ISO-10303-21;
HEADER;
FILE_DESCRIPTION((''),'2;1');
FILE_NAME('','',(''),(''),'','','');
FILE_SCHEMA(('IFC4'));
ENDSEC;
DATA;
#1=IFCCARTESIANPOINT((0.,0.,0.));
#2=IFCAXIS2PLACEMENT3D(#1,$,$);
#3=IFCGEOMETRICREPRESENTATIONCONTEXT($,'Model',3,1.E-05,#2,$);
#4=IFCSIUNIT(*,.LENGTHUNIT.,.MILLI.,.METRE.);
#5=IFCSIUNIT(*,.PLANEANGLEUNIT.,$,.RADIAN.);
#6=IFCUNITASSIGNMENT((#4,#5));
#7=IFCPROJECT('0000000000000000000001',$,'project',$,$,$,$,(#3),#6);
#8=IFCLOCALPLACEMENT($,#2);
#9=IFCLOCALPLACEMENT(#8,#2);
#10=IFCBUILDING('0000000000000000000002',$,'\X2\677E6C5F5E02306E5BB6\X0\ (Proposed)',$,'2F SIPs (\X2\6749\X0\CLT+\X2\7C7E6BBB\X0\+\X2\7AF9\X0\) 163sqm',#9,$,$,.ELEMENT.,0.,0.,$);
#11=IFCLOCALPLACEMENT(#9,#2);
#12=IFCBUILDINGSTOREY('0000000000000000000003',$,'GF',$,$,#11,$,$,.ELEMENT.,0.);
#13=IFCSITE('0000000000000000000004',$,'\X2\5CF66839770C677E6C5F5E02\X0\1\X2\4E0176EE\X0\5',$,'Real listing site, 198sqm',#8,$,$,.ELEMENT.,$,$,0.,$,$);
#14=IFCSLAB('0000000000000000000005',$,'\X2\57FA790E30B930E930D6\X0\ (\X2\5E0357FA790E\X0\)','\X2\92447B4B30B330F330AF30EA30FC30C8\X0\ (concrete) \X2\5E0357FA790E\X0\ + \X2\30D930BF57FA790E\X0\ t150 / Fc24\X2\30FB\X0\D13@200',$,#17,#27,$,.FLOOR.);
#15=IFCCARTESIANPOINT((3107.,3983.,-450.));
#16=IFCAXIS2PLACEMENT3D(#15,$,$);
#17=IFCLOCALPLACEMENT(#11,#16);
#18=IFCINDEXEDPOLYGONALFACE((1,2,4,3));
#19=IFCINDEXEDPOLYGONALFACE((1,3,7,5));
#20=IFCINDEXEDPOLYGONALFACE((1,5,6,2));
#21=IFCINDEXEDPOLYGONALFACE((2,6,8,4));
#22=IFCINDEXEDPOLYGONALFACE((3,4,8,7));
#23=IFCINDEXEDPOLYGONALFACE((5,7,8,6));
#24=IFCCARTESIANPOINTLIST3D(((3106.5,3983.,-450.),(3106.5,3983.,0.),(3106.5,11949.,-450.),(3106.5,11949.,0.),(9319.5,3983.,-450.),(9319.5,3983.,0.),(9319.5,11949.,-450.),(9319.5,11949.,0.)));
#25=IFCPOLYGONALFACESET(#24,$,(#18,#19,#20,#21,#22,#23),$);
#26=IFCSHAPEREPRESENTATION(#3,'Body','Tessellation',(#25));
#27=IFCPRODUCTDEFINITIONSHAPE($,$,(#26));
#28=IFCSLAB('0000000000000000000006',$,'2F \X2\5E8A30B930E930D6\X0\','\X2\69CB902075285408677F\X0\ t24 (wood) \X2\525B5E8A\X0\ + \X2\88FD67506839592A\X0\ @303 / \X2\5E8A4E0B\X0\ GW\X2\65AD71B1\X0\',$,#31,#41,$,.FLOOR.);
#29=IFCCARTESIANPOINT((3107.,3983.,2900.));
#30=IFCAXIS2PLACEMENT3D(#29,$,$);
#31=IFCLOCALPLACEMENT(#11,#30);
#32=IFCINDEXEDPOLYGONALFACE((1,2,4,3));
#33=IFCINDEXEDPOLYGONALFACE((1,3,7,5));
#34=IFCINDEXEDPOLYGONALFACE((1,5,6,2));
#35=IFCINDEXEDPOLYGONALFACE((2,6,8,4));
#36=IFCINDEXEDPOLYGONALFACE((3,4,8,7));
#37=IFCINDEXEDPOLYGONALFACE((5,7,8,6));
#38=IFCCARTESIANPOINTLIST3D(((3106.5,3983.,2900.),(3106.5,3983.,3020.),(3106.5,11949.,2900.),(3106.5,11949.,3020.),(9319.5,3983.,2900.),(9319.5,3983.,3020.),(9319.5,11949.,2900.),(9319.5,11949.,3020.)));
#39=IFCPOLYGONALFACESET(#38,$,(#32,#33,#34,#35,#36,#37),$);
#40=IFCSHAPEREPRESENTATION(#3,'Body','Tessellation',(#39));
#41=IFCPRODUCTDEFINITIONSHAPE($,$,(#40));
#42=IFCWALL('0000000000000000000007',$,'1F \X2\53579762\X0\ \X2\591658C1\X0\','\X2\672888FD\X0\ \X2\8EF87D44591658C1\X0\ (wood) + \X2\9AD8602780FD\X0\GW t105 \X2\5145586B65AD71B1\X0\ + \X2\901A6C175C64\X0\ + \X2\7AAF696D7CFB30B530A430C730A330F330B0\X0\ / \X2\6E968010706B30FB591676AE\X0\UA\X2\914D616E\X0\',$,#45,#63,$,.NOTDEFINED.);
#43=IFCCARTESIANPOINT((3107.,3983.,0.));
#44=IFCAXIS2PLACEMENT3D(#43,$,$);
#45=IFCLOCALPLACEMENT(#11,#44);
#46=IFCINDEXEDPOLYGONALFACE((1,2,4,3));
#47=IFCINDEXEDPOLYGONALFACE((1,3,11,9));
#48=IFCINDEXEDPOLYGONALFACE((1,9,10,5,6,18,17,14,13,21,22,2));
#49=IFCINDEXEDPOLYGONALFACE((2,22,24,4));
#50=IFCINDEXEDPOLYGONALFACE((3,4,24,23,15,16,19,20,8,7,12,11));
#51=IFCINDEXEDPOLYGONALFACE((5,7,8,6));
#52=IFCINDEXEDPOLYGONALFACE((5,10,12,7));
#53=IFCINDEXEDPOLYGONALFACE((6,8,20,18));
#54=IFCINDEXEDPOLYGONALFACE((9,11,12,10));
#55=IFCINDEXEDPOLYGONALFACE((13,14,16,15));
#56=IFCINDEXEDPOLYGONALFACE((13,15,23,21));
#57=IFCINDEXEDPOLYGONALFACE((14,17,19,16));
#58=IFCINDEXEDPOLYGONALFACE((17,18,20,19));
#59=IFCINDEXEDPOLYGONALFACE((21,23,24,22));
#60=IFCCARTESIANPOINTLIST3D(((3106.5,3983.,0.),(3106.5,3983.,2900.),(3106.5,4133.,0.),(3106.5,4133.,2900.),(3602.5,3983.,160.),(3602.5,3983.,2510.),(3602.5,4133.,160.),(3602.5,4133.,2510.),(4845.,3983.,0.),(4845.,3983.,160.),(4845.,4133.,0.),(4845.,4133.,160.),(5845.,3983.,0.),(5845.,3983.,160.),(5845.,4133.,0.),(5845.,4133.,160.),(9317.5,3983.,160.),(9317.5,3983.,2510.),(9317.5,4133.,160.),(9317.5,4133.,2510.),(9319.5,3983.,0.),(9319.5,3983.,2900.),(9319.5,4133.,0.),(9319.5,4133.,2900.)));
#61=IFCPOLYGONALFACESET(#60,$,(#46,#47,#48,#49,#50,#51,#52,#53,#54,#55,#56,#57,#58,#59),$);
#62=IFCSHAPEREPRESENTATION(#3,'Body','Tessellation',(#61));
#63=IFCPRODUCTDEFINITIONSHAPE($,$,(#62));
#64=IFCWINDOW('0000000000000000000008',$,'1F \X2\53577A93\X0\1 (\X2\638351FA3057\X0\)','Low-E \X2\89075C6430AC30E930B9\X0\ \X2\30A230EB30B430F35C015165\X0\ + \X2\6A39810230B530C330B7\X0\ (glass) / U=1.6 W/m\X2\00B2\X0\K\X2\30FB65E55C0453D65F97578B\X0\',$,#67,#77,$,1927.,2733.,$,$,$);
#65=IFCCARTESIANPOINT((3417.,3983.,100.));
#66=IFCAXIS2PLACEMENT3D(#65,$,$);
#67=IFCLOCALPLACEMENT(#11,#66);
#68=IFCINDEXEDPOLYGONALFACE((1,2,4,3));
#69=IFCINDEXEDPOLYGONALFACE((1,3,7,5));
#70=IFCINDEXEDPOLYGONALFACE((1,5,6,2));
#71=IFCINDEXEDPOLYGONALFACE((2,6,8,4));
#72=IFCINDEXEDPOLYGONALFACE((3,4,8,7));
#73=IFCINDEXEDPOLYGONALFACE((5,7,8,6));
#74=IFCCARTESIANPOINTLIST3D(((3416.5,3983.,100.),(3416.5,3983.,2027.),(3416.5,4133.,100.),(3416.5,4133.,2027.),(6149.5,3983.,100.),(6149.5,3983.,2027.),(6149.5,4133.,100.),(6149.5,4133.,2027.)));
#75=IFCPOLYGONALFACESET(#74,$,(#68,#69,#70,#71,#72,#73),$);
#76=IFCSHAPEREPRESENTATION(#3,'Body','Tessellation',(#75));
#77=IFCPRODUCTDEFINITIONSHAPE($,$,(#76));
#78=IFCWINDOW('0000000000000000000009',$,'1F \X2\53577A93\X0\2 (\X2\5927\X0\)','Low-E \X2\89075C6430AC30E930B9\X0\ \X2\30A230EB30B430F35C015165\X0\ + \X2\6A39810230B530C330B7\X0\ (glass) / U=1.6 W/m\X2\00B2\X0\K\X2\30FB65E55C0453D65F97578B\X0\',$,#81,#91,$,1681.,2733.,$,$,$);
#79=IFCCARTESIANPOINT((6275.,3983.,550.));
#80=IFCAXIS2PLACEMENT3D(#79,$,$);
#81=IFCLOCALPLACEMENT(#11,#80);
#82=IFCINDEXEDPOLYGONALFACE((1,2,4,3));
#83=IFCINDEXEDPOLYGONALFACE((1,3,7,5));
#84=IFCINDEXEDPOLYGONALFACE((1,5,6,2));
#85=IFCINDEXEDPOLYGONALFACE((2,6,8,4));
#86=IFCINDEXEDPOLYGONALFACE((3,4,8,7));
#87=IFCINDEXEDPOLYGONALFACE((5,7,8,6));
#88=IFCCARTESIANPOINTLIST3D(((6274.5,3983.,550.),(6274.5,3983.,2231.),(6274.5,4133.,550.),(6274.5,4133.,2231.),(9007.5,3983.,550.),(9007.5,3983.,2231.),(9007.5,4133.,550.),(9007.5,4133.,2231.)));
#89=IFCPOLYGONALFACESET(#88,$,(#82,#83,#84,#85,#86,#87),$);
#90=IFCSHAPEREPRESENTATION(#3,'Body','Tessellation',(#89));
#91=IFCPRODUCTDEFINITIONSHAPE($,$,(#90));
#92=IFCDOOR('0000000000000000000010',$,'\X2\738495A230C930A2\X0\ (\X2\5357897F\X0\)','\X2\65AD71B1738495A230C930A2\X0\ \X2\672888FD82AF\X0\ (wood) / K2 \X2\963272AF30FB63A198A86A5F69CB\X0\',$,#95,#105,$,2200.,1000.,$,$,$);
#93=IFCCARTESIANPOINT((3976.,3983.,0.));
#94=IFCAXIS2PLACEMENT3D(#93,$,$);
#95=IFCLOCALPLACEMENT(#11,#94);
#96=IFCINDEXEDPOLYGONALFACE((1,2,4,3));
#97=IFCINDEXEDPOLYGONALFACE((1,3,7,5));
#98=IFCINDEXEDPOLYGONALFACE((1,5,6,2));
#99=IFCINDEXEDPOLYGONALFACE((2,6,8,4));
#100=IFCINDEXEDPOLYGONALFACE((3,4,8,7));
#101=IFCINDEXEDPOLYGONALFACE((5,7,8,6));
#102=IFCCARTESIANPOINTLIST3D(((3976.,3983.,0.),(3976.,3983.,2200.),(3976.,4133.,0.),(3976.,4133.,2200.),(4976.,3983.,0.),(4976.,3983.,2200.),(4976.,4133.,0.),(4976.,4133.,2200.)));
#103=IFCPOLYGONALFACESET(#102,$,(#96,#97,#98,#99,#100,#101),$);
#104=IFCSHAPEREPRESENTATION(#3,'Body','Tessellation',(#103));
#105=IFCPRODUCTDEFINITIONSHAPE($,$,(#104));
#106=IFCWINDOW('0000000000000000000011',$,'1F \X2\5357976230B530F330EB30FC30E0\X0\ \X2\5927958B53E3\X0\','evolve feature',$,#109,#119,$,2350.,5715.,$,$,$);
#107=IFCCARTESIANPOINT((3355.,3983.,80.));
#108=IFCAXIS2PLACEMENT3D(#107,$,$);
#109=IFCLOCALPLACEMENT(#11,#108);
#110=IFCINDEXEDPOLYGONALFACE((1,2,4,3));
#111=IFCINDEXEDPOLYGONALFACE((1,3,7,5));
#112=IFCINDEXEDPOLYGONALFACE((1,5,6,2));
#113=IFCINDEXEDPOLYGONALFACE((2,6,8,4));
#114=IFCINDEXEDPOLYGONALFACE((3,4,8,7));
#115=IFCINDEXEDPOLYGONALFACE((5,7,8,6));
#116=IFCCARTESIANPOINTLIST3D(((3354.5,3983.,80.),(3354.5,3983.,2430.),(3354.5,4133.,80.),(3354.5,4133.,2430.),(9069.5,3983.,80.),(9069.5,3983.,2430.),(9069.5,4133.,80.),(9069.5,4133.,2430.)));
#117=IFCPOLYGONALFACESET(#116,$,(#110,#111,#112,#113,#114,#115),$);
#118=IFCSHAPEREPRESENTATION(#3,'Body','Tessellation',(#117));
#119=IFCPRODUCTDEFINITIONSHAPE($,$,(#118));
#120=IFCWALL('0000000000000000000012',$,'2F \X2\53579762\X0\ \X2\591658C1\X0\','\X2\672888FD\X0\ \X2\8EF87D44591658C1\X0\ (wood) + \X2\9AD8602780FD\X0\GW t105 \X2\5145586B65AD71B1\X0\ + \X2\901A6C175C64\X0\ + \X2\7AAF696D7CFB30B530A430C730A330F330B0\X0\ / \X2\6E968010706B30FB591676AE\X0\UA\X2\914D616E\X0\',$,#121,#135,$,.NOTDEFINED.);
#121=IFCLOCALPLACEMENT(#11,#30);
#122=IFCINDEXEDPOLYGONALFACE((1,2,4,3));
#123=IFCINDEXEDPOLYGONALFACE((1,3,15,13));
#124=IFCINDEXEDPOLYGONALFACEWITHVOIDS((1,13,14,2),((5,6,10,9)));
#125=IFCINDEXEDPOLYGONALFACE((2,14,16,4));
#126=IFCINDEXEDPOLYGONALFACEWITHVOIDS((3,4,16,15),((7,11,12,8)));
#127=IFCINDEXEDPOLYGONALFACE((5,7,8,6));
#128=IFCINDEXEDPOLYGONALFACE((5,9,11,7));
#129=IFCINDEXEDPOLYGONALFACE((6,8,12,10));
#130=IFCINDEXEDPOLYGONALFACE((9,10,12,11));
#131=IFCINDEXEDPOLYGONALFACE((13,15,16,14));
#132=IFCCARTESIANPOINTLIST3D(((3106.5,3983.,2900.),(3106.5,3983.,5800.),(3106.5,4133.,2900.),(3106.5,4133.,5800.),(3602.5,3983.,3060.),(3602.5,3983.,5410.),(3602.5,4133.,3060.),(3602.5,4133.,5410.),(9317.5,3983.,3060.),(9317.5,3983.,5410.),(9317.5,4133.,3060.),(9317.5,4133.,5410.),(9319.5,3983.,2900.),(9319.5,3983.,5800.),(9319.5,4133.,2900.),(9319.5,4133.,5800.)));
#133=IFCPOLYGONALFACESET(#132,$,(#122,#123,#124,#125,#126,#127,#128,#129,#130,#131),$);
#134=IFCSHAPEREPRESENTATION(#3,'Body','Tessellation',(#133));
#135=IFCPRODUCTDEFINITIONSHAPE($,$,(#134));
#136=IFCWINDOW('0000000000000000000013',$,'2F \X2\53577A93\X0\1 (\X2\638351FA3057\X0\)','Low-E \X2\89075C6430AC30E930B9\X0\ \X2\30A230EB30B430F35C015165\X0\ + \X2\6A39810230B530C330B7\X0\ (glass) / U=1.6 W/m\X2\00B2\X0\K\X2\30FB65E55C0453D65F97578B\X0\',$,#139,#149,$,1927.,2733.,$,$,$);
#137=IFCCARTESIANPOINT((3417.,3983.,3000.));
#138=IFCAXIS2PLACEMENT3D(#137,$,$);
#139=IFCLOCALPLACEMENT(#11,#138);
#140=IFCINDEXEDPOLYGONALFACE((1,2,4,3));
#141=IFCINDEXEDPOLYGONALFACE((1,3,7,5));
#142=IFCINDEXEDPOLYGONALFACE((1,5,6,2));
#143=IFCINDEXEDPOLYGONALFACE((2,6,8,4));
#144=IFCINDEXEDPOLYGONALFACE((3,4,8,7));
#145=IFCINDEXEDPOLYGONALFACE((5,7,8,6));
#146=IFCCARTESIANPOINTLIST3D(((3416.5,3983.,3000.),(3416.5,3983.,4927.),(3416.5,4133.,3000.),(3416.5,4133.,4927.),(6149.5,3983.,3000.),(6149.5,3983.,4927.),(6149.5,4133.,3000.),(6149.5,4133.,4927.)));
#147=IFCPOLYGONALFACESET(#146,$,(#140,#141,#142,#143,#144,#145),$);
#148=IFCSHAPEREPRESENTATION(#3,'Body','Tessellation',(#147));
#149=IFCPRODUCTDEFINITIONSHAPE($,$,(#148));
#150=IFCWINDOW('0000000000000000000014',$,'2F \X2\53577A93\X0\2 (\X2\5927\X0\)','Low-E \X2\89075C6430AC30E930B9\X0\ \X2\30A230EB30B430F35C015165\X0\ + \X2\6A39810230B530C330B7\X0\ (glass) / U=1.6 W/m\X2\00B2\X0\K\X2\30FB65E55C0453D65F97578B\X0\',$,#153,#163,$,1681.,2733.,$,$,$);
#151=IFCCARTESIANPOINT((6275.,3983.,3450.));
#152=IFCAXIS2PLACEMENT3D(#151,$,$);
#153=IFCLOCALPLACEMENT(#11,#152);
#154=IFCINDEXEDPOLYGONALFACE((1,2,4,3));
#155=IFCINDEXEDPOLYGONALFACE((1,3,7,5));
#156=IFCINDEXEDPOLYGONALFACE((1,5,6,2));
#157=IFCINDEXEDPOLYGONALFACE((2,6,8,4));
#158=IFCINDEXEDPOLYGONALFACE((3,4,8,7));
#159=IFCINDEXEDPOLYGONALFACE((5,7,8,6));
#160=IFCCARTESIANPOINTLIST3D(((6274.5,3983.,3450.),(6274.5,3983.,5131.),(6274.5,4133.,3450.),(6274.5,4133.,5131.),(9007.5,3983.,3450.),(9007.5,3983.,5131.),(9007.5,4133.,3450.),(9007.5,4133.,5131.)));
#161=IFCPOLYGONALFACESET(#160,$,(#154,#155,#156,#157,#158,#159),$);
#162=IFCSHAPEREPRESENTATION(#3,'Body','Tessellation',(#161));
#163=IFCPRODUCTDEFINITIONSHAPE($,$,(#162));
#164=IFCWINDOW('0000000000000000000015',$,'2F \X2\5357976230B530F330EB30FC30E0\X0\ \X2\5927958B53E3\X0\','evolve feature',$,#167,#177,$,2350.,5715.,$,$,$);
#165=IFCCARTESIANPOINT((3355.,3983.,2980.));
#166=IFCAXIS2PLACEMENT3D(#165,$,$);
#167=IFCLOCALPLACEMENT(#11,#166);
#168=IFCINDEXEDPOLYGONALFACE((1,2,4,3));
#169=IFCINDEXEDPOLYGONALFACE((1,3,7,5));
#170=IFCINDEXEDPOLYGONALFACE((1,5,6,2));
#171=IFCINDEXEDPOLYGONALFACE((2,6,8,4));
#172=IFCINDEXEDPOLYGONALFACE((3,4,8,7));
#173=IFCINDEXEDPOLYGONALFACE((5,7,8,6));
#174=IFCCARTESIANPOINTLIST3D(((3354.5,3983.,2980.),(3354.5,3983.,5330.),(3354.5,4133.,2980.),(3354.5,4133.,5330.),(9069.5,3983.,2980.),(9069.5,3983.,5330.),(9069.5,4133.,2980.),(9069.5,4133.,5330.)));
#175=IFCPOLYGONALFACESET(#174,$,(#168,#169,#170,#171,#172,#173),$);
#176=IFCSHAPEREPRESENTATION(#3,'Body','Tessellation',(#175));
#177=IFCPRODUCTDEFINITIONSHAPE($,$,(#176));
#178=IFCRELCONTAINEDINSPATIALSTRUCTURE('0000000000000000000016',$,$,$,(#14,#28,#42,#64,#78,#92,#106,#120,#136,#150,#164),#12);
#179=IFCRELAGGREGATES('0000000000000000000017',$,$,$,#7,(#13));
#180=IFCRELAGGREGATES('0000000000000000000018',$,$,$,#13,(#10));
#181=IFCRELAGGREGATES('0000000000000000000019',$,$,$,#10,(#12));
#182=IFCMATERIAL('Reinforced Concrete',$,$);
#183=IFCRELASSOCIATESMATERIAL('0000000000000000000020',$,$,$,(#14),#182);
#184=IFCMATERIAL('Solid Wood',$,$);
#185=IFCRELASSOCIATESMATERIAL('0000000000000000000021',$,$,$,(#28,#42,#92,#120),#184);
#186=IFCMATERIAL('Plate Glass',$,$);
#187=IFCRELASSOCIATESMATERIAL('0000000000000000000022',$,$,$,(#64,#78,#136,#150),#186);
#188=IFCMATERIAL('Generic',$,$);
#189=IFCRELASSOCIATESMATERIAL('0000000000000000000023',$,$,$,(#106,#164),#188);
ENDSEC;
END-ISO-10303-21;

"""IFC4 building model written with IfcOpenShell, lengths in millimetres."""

from ifc_helpers import new_model, si_unit, frame, frame_2d, origin, place, context, project, spatial, rectangle, extrude, material, element, fill, save


model = new_model("IFC4")

# Units and contexts
model_context = context("Model", 3, precision=1e-05, world=origin())
ifc_project = project(units=[si_unit("LENGTHUNIT", "METRE", prefix="MILLI"), si_unit("PLANEANGLEUNIT", "RADIAN")], contexts=[model_context])

# Site, building, storey
site_placement = place(None, origin())
site = spatial("IfcSite", under=ifc_project, at=site_placement, Name="島根県松江市1丁目5", ObjectType="Real listing site, 198sqm", CompositionType="ELEMENT", RefElevation=0.0)
building_placement = place(site_placement, origin())
building = spatial("IfcBuilding", under=site, at=building_placement, Name="松江市の家 (Proposed)", ObjectType="2F SIPs (杉CLT+籾殻+竹) 163sqm", CompositionType="ELEMENT", ElevationOfRefHeight=0.0, ElevationOfTerrain=0.0)
storey_placement = place(building_placement, origin())
storey = spatial("IfcBuildingStorey", under=building, at=storey_placement, Name="GF", CompositionType="ELEMENT", Elevation=0.0)

# Slabs
ifc_material_1 = material(Name="Reinforced Concrete")
slab_1_placement = place(storey_placement, frame((3107.0, 3983.0, -450.0)))
element("IfcSlab", 1, at=slab_1_placement, inside=storey, material=ifc_material_1, Name="基礎スラブ (布基礎)", Description="鉄筋コンクリート (concrete) 布基礎 + ベタ基礎 t150 / Fc24・D13@200", PredefinedType="FLOOR", context=model_context, shape_type="SweptSolid", body=[
    extrude(rectangle(XDim=6213.0, YDim=7966.0, at=frame_2d((3106.0, 3983.0))), frame((3107.0, 3983.0, -450.0)), (0.0, 0.0, 1.0), 450.0),
])
ifc_material_2 = material(Name="Solid Wood")
slab_2_placement = place(storey_placement, frame((3107.0, 3983.0, 2900.0)))
element("IfcSlab", 2, at=slab_2_placement, inside=storey, material=ifc_material_2, Name="2F 床スラブ", Description="構造用合板 t24 (wood) 剛床 + 製材根太 @303 / 床下 GW断熱", PredefinedType="FLOOR", context=model_context, shape_type="SweptSolid", body=[
    extrude(rectangle(XDim=6213.0, YDim=7966.0, at=frame_2d((3106.0, 3983.0))), frame((3107.0, 3983.0, 2900.0)), (0.0, 0.0, 1.0), 120.0),
])
ifc_material_3 = material(Name="Generic")

# Wall, openings, windows, door
wall_1_placement = place(storey_placement, frame((3107.0, 3983.0, 0.0)))
wall_1 = element("IfcWall", 3, at=wall_1_placement, inside=storey, material=ifc_material_2, Name="1F 南面 外壁", Description="木製 軸組外壁 (wood) + 高性能GW t105 充填断熱 + 通気層 + 窯業系サイディング / 準耐火・外皮UA配慮", PredefinedType="NOTDEFINED", context=model_context, shape_type="SweptSolid", body=[
    extrude(rectangle(XDim=6213.0, YDim=150.0, at=frame_2d((3106.0, 75.0))), frame((3107.0, 3983.0, 0.0)), (0.0, 0.0, 1.0), 2900.0),
])
opening_1_placement = place(storey_placement, frame((3417.0, 3983.0, 100.0)))
opening_1 = element("IfcOpeningElement", 4, at=opening_1_placement, cuts=wall_1, PredefinedType="NOTDEFINED", context=model_context, shape_type="SweptSolid", body=[
    extrude(rectangle(XDim=2733.0, YDim=150.0, at=frame_2d((1366.0, 75.0))), frame((3417.0, 3983.0, 100.0)), (0.0, 0.0, 1.0), 1927.0),
])
opening_2_placement = place(storey_placement, frame((6275.0, 3983.0, 550.0)))
opening_2 = element("IfcOpeningElement", 5, at=opening_2_placement, cuts=wall_1, PredefinedType="NOTDEFINED", context=model_context, shape_type="SweptSolid", body=[
    extrude(rectangle(XDim=2733.0, YDim=150.0, at=frame_2d((1366.0, 75.0))), frame((6275.0, 3983.0, 550.0)), (0.0, 0.0, 1.0), 1681.0),
])
opening_3_placement = place(storey_placement, frame((3976.0, 3983.0, 0.0)))
opening_3 = element("IfcOpeningElement", 6, at=opening_3_placement, cuts=wall_1, PredefinedType="NOTDEFINED", context=model_context, shape_type="SweptSolid", body=[
    extrude(rectangle(XDim=1000.0, YDim=150.0, at=frame_2d((500.0, 75.0))), frame((3976.0, 3983.0, 0.0)), (0.0, 0.0, 1.0), 2200.0),
])
opening_4_placement = place(storey_placement, frame((3355.0, 3983.0, 80.0)))
opening_4 = element("IfcOpeningElement", 7, at=opening_4_placement, cuts=wall_1, PredefinedType="NOTDEFINED", context=model_context, shape_type="SweptSolid", body=[
    extrude(rectangle(XDim=5715.0, YDim=150.0, at=frame_2d((2857.0, 75.0))), frame((3355.0, 3983.0, 80.0)), (0.0, 0.0, 1.0), 2350.0),
])
ifc_material_4 = material(Name="Plate Glass")
window_1_placement = place(storey_placement, frame((3417.0, 3983.0, 100.0)))
window_1 = element("IfcWindow", 8, at=window_1_placement, inside=storey, material=ifc_material_4, Name="1F 南窓1 (掃出し)", Description="Low-E 複層ガラス アルゴン封入 + 樹脂サッシ (glass) / U=1.6 W/m²K・日射取得型", OverallHeight=1927.0, OverallWidth=2733.0, context=model_context, shape_type="SweptSolid", body=[
    extrude(rectangle(XDim=2733.0, YDim=150.0, at=frame_2d((1366.0, 75.0))), frame((3417.0, 3983.0, 100.0)), (0.0, 0.0, 1.0), 1927.0),
])
fill(opening_1, window_1)
window_2_placement = place(storey_placement, frame((6275.0, 3983.0, 550.0)))
window_2 = element("IfcWindow", 9, at=window_2_placement, inside=storey, material=ifc_material_4, Name="1F 南窓2 (大)", Description="Low-E 複層ガラス アルゴン封入 + 樹脂サッシ (glass) / U=1.6 W/m²K・日射取得型", OverallHeight=1681.0, OverallWidth=2733.0, context=model_context, shape_type="SweptSolid", body=[
    extrude(rectangle(XDim=2733.0, YDim=150.0, at=frame_2d((1366.0, 75.0))), frame((6275.0, 3983.0, 550.0)), (0.0, 0.0, 1.0), 1681.0),
])
fill(opening_2, window_2)
door_placement = place(storey_placement, frame((3976.0, 3983.0, 0.0)))
door = element("IfcDoor", 10, at=door_placement, inside=storey, material=ifc_material_2, Name="玄関ドア (南西)", Description="断熱玄関ドア 木製芯 (wood) / K2 防犯・採風機構", OverallHeight=2200.0, OverallWidth=1000.0, context=model_context, shape_type="SweptSolid", body=[
    extrude(rectangle(XDim=1000.0, YDim=150.0, at=frame_2d((500.0, 75.0))), frame((3976.0, 3983.0, 0.0)), (0.0, 0.0, 1.0), 2200.0),
])
fill(opening_3, door)
window_3_placement = place(storey_placement, frame((3355.0, 3983.0, 80.0)))
window_3 = element("IfcWindow", 11, at=window_3_placement, inside=storey, material=ifc_material_3, Name="1F 南面サンルーム 大開口", Description="evolve feature", OverallHeight=2350.0, OverallWidth=5715.0, context=model_context, shape_type="SweptSolid", body=[
    extrude(rectangle(XDim=5715.0, YDim=150.0, at=frame_2d((2857.0, 75.0))), frame((3355.0, 3983.0, 80.0)), (0.0, 0.0, 1.0), 2350.0),
])
fill(opening_4, window_3)

# Wall, openings, windows
wall_2_placement = place(storey_placement, frame((3107.0, 3983.0, 2900.0)))
wall_2 = element("IfcWall", 12, at=wall_2_placement, inside=storey, material=ifc_material_2, Name="2F 南面 外壁", Description="木製 軸組外壁 (wood) + 高性能GW t105 充填断熱 + 通気層 + 窯業系サイディング / 準耐火・外皮UA配慮", PredefinedType="NOTDEFINED", context=model_context, shape_type="SweptSolid", body=[
    extrude(rectangle(XDim=6213.0, YDim=150.0, at=frame_2d((3106.0, 75.0))), frame((3107.0, 3983.0, 2900.0)), (0.0, 0.0, 1.0), 2900.0),
])
opening_5_placement = place(storey_placement, frame((3417.0, 3983.0, 3000.0)))
opening_5 = element("IfcOpeningElement", 13, at=opening_5_placement, cuts=wall_2, PredefinedType="NOTDEFINED", context=model_context, shape_type="SweptSolid", body=[
    extrude(rectangle(XDim=2733.0, YDim=150.0, at=frame_2d((1366.0, 75.0))), frame((3417.0, 3983.0, 3000.0)), (0.0, 0.0, 1.0), 1927.0),
])
opening_6_placement = place(storey_placement, frame((6275.0, 3983.0, 3450.0)))
opening_6 = element("IfcOpeningElement", 14, at=opening_6_placement, cuts=wall_2, PredefinedType="NOTDEFINED", context=model_context, shape_type="SweptSolid", body=[
    extrude(rectangle(XDim=2733.0, YDim=150.0, at=frame_2d((1366.0, 75.0))), frame((6275.0, 3983.0, 3450.0)), (0.0, 0.0, 1.0), 1681.0),
])
opening_7_placement = place(storey_placement, frame((3355.0, 3983.0, 2980.0)))
opening_7 = element("IfcOpeningElement", 15, at=opening_7_placement, cuts=wall_2, PredefinedType="NOTDEFINED", context=model_context, shape_type="SweptSolid", body=[
    extrude(rectangle(XDim=5715.0, YDim=150.0, at=frame_2d((2857.0, 75.0))), frame((3355.0, 3983.0, 2980.0)), (0.0, 0.0, 1.0), 2350.0),
])
window_4_placement = place(storey_placement, frame((3417.0, 3983.0, 3000.0)))
window_4 = element("IfcWindow", 16, at=window_4_placement, inside=storey, material=ifc_material_4, Name="2F 南窓1 (掃出し)", Description="Low-E 複層ガラス アルゴン封入 + 樹脂サッシ (glass) / U=1.6 W/m²K・日射取得型", OverallHeight=1927.0, OverallWidth=2733.0, context=model_context, shape_type="SweptSolid", body=[
    extrude(rectangle(XDim=2733.0, YDim=150.0, at=frame_2d((1366.0, 75.0))), frame((3417.0, 3983.0, 3000.0)), (0.0, 0.0, 1.0), 1927.0),
])
fill(opening_5, window_4)
window_5_placement = place(storey_placement, frame((6275.0, 3983.0, 3450.0)))
window_5 = element("IfcWindow", 17, at=window_5_placement, inside=storey, material=ifc_material_4, Name="2F 南窓2 (大)", Description="Low-E 複層ガラス アルゴン封入 + 樹脂サッシ (glass) / U=1.6 W/m²K・日射取得型", OverallHeight=1681.0, OverallWidth=2733.0, context=model_context, shape_type="SweptSolid", body=[
    extrude(rectangle(XDim=2733.0, YDim=150.0, at=frame_2d((1366.0, 75.0))), frame((6275.0, 3983.0, 3450.0)), (0.0, 0.0, 1.0), 1681.0),
])
fill(opening_6, window_5)
window_6_placement = place(storey_placement, frame((3355.0, 3983.0, 2980.0)))
window_6 = element("IfcWindow", 18, at=window_6_placement, inside=storey, material=ifc_material_3, Name="2F 南面サンルーム 大開口", Description="evolve feature", OverallHeight=2350.0, OverallWidth=5715.0, context=model_context, shape_type="SweptSolid", body=[
    extrude(rectangle(XDim=5715.0, YDim=150.0, at=frame_2d((2857.0, 75.0))), frame((3355.0, 3983.0, 2980.0)), (0.0, 0.0, 1.0), 2350.0),
])
fill(opening_7, window_6)

save(model, "model.ifc")
